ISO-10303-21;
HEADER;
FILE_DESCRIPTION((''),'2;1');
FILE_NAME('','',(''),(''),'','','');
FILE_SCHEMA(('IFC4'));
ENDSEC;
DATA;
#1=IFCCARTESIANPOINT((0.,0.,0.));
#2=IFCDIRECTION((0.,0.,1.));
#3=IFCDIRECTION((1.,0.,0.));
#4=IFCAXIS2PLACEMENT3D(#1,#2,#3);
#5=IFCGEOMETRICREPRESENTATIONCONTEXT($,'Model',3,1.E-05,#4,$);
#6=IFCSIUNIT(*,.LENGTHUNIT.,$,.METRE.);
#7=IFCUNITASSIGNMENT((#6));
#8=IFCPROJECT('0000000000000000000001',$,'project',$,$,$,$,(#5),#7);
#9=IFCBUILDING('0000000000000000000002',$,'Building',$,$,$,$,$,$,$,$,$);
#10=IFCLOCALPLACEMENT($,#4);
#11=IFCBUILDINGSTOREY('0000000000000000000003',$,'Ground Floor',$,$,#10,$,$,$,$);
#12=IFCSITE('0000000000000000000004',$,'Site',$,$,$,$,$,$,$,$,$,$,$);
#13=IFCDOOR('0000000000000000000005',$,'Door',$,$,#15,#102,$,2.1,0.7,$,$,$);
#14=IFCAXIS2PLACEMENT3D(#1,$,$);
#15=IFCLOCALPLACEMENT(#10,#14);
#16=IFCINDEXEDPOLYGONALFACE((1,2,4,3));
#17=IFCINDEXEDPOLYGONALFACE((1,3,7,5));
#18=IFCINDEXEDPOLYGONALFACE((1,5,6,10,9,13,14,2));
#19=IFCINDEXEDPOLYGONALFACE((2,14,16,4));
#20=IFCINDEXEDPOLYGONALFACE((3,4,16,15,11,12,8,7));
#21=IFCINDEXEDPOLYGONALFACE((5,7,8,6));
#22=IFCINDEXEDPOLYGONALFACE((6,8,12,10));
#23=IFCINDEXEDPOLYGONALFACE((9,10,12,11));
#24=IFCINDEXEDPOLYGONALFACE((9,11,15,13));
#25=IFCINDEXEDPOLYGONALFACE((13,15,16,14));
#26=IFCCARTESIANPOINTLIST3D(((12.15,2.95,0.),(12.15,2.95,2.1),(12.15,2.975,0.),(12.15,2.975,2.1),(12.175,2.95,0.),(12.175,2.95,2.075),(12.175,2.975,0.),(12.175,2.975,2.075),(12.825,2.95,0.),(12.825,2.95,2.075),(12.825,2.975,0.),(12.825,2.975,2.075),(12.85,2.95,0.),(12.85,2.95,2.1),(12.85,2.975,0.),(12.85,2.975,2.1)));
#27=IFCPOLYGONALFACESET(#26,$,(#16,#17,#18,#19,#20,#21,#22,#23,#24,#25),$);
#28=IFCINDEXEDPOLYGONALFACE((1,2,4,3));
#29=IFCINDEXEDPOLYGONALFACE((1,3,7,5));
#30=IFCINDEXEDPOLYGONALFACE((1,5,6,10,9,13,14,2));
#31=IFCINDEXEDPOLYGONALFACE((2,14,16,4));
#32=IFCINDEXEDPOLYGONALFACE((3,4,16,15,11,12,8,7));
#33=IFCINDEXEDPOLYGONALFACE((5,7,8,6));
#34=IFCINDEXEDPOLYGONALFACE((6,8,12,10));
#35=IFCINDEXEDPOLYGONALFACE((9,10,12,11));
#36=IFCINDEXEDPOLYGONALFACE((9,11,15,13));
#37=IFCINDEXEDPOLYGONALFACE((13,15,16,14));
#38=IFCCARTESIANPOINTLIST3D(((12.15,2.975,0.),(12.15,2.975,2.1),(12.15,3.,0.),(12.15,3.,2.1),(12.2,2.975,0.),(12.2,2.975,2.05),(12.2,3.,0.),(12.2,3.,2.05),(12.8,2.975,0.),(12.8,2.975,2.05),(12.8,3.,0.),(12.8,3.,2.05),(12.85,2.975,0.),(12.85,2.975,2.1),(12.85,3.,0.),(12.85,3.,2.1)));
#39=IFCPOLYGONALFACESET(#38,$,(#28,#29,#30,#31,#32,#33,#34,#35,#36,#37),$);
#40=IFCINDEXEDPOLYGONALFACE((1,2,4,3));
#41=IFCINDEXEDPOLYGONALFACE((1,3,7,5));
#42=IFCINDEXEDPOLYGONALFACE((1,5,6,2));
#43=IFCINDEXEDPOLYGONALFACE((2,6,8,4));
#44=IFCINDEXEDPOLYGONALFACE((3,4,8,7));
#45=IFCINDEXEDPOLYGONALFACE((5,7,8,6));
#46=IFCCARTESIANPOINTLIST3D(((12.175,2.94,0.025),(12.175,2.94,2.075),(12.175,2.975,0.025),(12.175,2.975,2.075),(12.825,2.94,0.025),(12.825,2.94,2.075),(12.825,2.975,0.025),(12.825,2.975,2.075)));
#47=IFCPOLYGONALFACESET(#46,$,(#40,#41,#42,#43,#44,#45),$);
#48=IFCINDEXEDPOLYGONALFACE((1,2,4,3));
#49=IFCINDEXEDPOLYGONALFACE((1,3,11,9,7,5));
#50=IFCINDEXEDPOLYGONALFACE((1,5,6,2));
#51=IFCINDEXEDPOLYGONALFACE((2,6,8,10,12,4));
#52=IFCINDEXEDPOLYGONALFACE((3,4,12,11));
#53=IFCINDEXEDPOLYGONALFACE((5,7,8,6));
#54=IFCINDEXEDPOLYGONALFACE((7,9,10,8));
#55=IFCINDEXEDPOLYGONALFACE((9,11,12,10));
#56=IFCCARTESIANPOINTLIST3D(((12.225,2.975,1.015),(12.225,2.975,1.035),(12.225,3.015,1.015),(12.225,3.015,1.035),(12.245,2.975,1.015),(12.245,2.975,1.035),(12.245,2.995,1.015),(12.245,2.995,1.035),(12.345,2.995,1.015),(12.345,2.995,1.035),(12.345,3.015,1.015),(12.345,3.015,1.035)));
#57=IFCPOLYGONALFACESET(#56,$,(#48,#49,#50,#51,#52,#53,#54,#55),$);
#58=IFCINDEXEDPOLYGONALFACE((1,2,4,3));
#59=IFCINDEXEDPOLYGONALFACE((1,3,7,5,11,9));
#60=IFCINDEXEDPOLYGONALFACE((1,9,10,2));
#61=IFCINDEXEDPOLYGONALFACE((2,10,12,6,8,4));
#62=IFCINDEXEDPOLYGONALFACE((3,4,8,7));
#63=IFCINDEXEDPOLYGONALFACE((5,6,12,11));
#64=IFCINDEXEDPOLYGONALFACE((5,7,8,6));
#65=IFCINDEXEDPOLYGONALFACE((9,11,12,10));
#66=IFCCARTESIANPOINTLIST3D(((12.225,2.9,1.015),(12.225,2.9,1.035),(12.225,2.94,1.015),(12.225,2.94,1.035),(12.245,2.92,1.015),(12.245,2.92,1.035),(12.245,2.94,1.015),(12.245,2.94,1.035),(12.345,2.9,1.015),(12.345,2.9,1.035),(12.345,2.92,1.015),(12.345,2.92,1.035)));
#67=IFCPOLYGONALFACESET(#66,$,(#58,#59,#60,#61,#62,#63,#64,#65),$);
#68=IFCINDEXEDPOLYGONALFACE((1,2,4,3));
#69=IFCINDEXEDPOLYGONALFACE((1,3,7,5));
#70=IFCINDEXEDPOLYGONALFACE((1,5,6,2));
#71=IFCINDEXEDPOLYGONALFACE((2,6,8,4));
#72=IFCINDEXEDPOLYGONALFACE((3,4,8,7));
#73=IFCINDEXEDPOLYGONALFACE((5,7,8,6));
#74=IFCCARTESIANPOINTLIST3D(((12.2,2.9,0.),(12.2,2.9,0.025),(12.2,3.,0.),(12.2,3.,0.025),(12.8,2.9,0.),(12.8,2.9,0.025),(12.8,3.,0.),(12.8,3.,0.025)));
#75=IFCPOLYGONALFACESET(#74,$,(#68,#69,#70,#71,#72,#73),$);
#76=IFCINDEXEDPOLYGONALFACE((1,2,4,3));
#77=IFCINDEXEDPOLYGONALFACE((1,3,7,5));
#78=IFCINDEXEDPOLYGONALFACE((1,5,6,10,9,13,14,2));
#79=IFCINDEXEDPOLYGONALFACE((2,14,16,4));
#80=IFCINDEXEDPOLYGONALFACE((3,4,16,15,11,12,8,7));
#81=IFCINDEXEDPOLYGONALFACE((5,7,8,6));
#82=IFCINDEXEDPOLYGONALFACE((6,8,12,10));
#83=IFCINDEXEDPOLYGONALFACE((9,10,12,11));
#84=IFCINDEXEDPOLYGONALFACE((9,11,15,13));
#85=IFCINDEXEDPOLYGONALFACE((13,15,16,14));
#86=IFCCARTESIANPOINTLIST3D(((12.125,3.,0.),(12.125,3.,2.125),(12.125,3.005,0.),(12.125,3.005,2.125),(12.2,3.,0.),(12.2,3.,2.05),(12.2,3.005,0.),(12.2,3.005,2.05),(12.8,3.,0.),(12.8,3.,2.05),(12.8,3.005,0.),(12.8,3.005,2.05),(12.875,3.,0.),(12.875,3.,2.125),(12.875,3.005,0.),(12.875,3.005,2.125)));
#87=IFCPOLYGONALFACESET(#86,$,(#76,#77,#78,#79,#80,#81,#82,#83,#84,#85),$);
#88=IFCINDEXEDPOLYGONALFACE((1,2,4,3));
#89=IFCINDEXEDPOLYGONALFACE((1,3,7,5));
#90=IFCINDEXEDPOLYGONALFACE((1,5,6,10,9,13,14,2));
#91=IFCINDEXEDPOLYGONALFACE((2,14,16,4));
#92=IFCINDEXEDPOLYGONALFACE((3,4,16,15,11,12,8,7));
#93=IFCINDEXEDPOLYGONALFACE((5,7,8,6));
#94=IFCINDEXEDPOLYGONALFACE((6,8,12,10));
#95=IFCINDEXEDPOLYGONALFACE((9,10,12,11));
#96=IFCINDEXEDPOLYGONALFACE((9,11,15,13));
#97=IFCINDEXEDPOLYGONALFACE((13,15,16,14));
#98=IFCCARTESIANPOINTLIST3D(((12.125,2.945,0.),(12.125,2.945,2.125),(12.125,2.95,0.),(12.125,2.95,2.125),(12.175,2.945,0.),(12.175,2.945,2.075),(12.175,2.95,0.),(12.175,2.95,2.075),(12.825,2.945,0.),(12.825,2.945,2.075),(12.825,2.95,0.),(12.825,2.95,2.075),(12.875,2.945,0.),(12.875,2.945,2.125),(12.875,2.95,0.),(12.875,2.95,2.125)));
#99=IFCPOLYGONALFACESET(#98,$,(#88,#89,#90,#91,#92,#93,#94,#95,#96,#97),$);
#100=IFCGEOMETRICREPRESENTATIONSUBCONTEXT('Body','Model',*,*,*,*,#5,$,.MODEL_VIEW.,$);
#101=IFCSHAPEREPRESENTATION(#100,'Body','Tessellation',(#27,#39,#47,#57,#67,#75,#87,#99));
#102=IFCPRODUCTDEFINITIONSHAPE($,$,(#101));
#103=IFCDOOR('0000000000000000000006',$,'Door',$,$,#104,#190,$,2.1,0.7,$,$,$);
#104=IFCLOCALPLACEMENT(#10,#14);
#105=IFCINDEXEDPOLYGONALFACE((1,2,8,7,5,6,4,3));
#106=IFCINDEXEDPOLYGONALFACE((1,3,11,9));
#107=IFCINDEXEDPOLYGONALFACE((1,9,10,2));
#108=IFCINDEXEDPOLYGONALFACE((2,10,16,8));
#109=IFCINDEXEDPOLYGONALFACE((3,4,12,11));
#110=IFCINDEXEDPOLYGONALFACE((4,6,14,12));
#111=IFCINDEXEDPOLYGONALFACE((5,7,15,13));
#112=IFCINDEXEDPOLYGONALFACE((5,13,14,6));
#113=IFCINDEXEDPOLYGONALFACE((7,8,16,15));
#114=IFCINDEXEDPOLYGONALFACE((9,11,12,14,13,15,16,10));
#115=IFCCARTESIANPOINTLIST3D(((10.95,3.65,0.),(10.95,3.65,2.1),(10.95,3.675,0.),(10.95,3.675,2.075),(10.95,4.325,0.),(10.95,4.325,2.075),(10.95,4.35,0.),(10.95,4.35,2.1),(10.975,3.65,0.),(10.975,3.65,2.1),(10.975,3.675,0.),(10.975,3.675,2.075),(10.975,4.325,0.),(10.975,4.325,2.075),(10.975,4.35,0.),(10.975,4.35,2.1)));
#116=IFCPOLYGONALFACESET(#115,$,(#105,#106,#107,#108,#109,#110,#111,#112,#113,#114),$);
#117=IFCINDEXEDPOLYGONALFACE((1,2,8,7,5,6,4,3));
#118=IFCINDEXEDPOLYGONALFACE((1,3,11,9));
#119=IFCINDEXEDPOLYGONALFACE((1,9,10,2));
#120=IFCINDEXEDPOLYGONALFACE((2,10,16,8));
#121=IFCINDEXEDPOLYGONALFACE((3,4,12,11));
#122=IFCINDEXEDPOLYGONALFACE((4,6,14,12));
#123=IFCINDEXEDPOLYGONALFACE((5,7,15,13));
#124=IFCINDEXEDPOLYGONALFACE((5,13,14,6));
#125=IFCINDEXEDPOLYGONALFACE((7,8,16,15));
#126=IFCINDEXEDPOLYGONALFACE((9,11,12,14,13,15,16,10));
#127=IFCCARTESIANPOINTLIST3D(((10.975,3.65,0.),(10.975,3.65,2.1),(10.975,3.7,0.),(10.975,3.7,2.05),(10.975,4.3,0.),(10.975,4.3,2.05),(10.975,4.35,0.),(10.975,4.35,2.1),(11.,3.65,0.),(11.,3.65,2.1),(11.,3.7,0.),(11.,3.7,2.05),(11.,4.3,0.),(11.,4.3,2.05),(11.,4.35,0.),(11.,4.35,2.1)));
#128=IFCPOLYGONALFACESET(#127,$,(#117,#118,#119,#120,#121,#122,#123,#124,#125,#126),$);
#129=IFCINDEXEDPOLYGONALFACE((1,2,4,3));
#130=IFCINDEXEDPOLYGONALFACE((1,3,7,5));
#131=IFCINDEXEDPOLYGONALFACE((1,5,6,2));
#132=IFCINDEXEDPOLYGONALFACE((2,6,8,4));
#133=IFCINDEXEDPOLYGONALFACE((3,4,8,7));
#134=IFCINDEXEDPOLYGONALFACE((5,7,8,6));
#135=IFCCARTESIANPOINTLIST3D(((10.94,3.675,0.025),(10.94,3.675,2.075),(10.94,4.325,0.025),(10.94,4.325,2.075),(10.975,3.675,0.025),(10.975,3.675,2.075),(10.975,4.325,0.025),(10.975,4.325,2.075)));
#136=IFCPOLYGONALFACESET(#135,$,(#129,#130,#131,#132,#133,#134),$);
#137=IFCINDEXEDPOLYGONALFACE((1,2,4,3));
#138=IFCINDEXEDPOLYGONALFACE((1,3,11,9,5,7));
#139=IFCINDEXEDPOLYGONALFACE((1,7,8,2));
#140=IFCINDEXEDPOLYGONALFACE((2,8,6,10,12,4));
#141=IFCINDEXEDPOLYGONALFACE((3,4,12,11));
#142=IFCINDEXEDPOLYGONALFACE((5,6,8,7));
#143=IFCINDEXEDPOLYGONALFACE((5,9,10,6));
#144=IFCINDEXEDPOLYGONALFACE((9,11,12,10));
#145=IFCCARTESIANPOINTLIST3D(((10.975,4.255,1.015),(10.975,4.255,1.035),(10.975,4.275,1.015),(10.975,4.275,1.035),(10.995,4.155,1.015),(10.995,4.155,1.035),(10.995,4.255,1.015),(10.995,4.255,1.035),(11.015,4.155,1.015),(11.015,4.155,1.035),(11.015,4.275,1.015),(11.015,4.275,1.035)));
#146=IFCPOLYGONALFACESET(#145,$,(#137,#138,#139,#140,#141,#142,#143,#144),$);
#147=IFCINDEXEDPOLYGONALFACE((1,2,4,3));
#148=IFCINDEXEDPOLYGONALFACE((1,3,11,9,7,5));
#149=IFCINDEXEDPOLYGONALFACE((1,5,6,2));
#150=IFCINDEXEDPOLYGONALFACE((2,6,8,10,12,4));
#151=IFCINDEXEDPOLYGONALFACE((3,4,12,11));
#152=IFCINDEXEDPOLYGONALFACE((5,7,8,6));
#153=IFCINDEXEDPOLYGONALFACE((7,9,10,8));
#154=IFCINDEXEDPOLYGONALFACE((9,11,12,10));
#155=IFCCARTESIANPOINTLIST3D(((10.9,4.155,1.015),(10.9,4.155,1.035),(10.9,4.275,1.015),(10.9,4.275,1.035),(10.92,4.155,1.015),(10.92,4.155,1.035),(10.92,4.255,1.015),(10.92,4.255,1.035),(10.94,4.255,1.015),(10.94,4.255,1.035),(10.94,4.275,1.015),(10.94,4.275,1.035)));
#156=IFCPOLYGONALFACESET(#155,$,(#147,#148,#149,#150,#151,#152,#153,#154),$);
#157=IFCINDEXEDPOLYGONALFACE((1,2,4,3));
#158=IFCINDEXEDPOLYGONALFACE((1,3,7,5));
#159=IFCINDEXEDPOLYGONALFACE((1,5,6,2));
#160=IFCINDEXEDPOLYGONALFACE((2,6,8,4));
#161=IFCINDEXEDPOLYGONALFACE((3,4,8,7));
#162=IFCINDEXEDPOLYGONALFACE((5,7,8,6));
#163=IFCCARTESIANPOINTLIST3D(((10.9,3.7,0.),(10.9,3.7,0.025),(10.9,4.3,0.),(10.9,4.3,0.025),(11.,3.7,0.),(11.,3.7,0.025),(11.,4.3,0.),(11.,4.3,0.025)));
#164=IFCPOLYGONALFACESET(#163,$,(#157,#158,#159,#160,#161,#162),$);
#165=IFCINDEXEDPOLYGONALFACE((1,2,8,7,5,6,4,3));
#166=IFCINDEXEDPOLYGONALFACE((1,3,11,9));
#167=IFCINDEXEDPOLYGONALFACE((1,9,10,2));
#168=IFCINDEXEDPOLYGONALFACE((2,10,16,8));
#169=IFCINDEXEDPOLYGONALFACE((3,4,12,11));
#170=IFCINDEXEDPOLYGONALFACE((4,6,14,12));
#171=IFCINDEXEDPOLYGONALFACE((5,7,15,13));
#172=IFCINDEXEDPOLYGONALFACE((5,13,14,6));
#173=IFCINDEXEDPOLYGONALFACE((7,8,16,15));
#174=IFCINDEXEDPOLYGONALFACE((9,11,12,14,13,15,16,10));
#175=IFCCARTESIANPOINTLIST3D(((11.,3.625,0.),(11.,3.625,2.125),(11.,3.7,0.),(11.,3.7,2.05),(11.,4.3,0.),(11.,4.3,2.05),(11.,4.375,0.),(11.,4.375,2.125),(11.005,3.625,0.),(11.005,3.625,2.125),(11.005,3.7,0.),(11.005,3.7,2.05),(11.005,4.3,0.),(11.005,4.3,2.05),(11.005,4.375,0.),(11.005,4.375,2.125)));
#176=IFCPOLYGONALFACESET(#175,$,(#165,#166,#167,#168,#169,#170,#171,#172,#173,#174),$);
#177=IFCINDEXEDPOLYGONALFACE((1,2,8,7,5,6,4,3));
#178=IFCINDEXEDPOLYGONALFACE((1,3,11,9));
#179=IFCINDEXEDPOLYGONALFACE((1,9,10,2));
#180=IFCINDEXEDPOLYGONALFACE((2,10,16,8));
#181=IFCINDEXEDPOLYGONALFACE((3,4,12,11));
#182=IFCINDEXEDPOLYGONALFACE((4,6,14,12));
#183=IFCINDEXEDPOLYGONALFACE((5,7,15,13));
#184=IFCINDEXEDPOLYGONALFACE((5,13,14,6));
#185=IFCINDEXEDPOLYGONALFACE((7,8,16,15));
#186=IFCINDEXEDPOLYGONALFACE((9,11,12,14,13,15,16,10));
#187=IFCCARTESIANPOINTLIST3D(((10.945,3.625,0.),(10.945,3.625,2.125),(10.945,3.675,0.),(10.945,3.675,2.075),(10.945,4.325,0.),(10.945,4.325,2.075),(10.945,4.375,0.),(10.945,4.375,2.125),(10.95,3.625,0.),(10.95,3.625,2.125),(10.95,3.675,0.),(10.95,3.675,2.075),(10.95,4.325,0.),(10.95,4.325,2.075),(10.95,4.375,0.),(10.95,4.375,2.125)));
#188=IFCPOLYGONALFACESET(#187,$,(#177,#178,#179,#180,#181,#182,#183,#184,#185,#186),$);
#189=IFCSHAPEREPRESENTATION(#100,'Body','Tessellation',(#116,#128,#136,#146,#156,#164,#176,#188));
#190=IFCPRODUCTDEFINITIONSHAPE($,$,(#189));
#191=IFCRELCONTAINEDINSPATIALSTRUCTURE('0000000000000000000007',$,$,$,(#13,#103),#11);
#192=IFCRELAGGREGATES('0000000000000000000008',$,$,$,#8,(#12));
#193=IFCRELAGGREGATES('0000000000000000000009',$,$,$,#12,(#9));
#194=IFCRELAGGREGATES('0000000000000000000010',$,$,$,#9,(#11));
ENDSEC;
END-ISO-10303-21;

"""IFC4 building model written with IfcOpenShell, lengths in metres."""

from ifc_helpers import new_model, si_unit, frame, origin_with_axes, place, context, subcontext, project, spatial, line, indexed_curve, outline, extrude, element, save


model = new_model("IFC4")

# Units and contexts
model_context = context("Model", 3, precision=1e-05, world=origin_with_axes())
body_context = subcontext(model_context, "Body", "Model", "MODEL_VIEW")
ifc_project = project(units=[si_unit("LENGTHUNIT", "METRE")], contexts=[model_context])

# Site, building, storey
site = spatial("IfcSite", under=ifc_project, Name="Site")
building = spatial("IfcBuilding", under=site, Name="Building")
storey_placement = place(None, origin_with_axes())
storey = spatial("IfcBuildingStorey", under=building, at=storey_placement, Name="Ground Floor")

# Doors
door_1_placement = place(storey_placement, frame((12.85, 3.0, 0.0), z_axis=(0.0, 0.0, 1.0), x_axis=(-1.0, 0.0, 0.0)))
element("IfcDoor", 1, at=door_1_placement, inside=storey, Name="Door", OverallHeight=2.1, OverallWidth=0.7, context=body_context, shape_type="SweptSolid", body=[
    extrude(outline(indexed_curve([(0.0, 0.0), (0.0, 2.1), (0.7, 2.1), (0.7, 0.0), (0.675, 0.0), (0.675, 2.075), (0.025, 2.075), (0.025, 0.0)], segments=[line(1, 2, 3, 4, 5, 6, 7, 8, 1)])), frame((0.0, 0.025, 0.0), z_axis=(0.0, -1.0, 0.0), x_axis=(1.0, 0.0, 0.0)), (0.0, 0.0, -1.0), 0.025),
    extrude(outline(indexed_curve([(0.0, 0.0), (0.0, 2.1), (0.7, 2.1), (0.7, 0.0), (0.65, 0.0), (0.65, 2.05), (0.05, 2.05), (0.05, 0.0)], segments=[line(1, 2, 3, 4, 5, 6, 7, 8, 1)])), frame((0.0, 0.0, 0.0), z_axis=(0.0, -1.0, 0.0), x_axis=(1.0, 0.0, 0.0)), (0.0, 0.0, -1.0), 0.025),
    extrude(outline(indexed_curve([(0.0, 0.0), (0.65, 0.0), (0.65, 0.035), (0.0, 0.035)], segments=[line(1, 2, 3, 4, 1)])), frame((0.025, 0.025, 0.025), z_axis=(0.0, 0.0, 1.0), x_axis=(1.0, 0.0, 0.0)), (0.0, 0.0, 1.0), 2.05),
    extrude(outline(indexed_curve([(0.0, 0.0), (0.0, -0.04), (-0.12, -0.04), (-0.12, -0.02), (-0.02, -0.02), (-0.02, 0.0)], segments=[line(1, 2, 3, 4, 5, 6, 1)])), frame((0.625, 0.025, 1.015), z_axis=(0.0, 0.0, 1.0), x_axis=(1.0, 0.0, 0.0)), (0.0, 0.0, 1.0), 0.02),
    extrude(outline(indexed_curve([(0.0, 0.0), (0.0, 0.04), (-0.12, 0.04), (-0.12, 0.02), (-0.02, 0.02), (-0.02, 0.0)], segments=[line(1, 2, 3, 4, 5, 6, 1)])), frame((0.625, 0.06, 1.015), z_axis=(0.0, 0.0, 1.0), x_axis=(1.0, 0.0, 0.0)), (0.0, 0.0, 1.0), 0.02),
    extrude(outline(indexed_curve([(0.0, 0.0), (0.6, 0.0), (0.6, 0.1), (0.0, 0.1)], segments=[line(1, 2, 3, 4, 1)])), frame((0.05, 0.0, 0.0), z_axis=(0.0, 0.0, 1.0), x_axis=(1.0, 0.0, 0.0)), (0.0, 0.0, 1.0), 0.025),
    extrude(outline(indexed_curve([(0.0, 0.0), (0.0, 2.125), (0.75, 2.125), (0.75, 0.0), (0.675, 0.0), (0.675, 2.05), (0.075, 2.05), (0.075, 0.0)], segments=[line(1, 2, 3, 4, 5, 6, 7, 8, 1)])), frame((-0.025, -0.005, 0.0), z_axis=(0.0, -1.0, 0.0), x_axis=(1.0, 0.0, 0.0)), (0.0, 0.0, -1.0), 0.005),
    extrude(outline(indexed_curve([(0.0, 0.0), (0.0, 2.125), (0.75, 2.125), (0.75, 0.0), (0.7, 0.0), (0.7, 2.075), (0.05, 2.075), (0.05, 0.0)], segments=[line(1, 2, 3, 4, 5, 6, 7, 8, 1)])), frame((-0.025, 0.05, 0.0), z_axis=(0.0, -1.0, 0.0), x_axis=(1.0, 0.0, 0.0)), (0.0, 0.0, -1.0), 0.005),
])
door_2_placement = place(storey_placement, frame((11.0, 3.65, 0.0), z_axis=(0.0, 0.0, 1.0), x_axis=(0.0, 1.0, 0.0)))
element("IfcDoor", 2, at=door_2_placement, inside=storey, Name="Door", OverallHeight=2.1, OverallWidth=0.7, context=body_context, shape_type="SweptSolid", body=[
    extrude(outline(indexed_curve([(0.0, 0.0), (0.0, 2.1), (0.7, 2.1), (0.7, 0.0), (0.675, 0.0), (0.675, 2.075), (0.025, 2.075), (0.025, 0.0)], segments=[line(1, 2, 3, 4, 5, 6, 7, 8, 1)])), frame((0.0, 0.025, 0.0), z_axis=(0.0, -1.0, 0.0), x_axis=(1.0, 0.0, 0.0)), (0.0, 0.0, -1.0), 0.025),
    extrude(outline(indexed_curve([(0.0, 0.0), (0.0, 2.1), (0.7, 2.1), (0.7, 0.0), (0.65, 0.0), (0.65, 2.05), (0.05, 2.05), (0.05, 0.0)], segments=[line(1, 2, 3, 4, 5, 6, 7, 8, 1)])), frame((0.0, 0.0, 0.0), z_axis=(0.0, -1.0, 0.0), x_axis=(1.0, 0.0, 0.0)), (0.0, 0.0, -1.0), 0.025),
    extrude(outline(indexed_curve([(0.0, 0.0), (0.65, 0.0), (0.65, 0.035), (0.0, 0.035)], segments=[line(1, 2, 3, 4, 1)])), frame((0.025, 0.025, 0.025), z_axis=(0.0, 0.0, 1.0), x_axis=(1.0, 0.0, 0.0)), (0.0, 0.0, 1.0), 2.05),
    extrude(outline(indexed_curve([(0.0, 0.0), (0.0, -0.04), (-0.12, -0.04), (-0.12, -0.02), (-0.02, -0.02), (-0.02, 0.0)], segments=[line(1, 2, 3, 4, 5, 6, 1)])), frame((0.625, 0.025, 1.015), z_axis=(0.0, 0.0, 1.0), x_axis=(1.0, 0.0, 0.0)), (0.0, 0.0, 1.0), 0.02),
    extrude(outline(indexed_curve([(0.0, 0.0), (0.0, 0.04), (-0.12, 0.04), (-0.12, 0.02), (-0.02, 0.02), (-0.02, 0.0)], segments=[line(1, 2, 3, 4, 5, 6, 1)])), frame((0.625, 0.06, 1.015), z_axis=(0.0, 0.0, 1.0), x_axis=(1.0, 0.0, 0.0)), (0.0, 0.0, 1.0), 0.02),
    extrude(outline(indexed_curve([(0.0, 0.0), (0.6, 0.0), (0.6, 0.1), (0.0, 0.1)], segments=[line(1, 2, 3, 4, 1)])), frame((0.05, 0.0, 0.0), z_axis=(0.0, 0.0, 1.0), x_axis=(1.0, 0.0, 0.0)), (0.0, 0.0, 1.0), 0.025),
    extrude(outline(indexed_curve([(0.0, 0.0), (0.0, 2.125), (0.75, 2.125), (0.75, 0.0), (0.675, 0.0), (0.675, 2.05), (0.075, 2.05), (0.075, 0.0)], segments=[line(1, 2, 3, 4, 5, 6, 7, 8, 1)])), frame((-0.025, -0.005, 0.0), z_axis=(0.0, -1.0, 0.0), x_axis=(1.0, 0.0, 0.0)), (0.0, 0.0, -1.0), 0.005),
    extrude(outline(indexed_curve([(0.0, 0.0), (0.0, 2.125), (0.75, 2.125), (0.75, 0.0), (0.7, 0.0), (0.7, 2.075), (0.05, 2.075), (0.05, 0.0)], segments=[line(1, 2, 3, 4, 5, 6, 7, 8, 1)])), frame((-0.025, 0.05, 0.0), z_axis=(0.0, -1.0, 0.0), x_axis=(1.0, 0.0, 0.0)), (0.0, 0.0, -1.0), 0.005),
])

save(model, "model.ifc")
